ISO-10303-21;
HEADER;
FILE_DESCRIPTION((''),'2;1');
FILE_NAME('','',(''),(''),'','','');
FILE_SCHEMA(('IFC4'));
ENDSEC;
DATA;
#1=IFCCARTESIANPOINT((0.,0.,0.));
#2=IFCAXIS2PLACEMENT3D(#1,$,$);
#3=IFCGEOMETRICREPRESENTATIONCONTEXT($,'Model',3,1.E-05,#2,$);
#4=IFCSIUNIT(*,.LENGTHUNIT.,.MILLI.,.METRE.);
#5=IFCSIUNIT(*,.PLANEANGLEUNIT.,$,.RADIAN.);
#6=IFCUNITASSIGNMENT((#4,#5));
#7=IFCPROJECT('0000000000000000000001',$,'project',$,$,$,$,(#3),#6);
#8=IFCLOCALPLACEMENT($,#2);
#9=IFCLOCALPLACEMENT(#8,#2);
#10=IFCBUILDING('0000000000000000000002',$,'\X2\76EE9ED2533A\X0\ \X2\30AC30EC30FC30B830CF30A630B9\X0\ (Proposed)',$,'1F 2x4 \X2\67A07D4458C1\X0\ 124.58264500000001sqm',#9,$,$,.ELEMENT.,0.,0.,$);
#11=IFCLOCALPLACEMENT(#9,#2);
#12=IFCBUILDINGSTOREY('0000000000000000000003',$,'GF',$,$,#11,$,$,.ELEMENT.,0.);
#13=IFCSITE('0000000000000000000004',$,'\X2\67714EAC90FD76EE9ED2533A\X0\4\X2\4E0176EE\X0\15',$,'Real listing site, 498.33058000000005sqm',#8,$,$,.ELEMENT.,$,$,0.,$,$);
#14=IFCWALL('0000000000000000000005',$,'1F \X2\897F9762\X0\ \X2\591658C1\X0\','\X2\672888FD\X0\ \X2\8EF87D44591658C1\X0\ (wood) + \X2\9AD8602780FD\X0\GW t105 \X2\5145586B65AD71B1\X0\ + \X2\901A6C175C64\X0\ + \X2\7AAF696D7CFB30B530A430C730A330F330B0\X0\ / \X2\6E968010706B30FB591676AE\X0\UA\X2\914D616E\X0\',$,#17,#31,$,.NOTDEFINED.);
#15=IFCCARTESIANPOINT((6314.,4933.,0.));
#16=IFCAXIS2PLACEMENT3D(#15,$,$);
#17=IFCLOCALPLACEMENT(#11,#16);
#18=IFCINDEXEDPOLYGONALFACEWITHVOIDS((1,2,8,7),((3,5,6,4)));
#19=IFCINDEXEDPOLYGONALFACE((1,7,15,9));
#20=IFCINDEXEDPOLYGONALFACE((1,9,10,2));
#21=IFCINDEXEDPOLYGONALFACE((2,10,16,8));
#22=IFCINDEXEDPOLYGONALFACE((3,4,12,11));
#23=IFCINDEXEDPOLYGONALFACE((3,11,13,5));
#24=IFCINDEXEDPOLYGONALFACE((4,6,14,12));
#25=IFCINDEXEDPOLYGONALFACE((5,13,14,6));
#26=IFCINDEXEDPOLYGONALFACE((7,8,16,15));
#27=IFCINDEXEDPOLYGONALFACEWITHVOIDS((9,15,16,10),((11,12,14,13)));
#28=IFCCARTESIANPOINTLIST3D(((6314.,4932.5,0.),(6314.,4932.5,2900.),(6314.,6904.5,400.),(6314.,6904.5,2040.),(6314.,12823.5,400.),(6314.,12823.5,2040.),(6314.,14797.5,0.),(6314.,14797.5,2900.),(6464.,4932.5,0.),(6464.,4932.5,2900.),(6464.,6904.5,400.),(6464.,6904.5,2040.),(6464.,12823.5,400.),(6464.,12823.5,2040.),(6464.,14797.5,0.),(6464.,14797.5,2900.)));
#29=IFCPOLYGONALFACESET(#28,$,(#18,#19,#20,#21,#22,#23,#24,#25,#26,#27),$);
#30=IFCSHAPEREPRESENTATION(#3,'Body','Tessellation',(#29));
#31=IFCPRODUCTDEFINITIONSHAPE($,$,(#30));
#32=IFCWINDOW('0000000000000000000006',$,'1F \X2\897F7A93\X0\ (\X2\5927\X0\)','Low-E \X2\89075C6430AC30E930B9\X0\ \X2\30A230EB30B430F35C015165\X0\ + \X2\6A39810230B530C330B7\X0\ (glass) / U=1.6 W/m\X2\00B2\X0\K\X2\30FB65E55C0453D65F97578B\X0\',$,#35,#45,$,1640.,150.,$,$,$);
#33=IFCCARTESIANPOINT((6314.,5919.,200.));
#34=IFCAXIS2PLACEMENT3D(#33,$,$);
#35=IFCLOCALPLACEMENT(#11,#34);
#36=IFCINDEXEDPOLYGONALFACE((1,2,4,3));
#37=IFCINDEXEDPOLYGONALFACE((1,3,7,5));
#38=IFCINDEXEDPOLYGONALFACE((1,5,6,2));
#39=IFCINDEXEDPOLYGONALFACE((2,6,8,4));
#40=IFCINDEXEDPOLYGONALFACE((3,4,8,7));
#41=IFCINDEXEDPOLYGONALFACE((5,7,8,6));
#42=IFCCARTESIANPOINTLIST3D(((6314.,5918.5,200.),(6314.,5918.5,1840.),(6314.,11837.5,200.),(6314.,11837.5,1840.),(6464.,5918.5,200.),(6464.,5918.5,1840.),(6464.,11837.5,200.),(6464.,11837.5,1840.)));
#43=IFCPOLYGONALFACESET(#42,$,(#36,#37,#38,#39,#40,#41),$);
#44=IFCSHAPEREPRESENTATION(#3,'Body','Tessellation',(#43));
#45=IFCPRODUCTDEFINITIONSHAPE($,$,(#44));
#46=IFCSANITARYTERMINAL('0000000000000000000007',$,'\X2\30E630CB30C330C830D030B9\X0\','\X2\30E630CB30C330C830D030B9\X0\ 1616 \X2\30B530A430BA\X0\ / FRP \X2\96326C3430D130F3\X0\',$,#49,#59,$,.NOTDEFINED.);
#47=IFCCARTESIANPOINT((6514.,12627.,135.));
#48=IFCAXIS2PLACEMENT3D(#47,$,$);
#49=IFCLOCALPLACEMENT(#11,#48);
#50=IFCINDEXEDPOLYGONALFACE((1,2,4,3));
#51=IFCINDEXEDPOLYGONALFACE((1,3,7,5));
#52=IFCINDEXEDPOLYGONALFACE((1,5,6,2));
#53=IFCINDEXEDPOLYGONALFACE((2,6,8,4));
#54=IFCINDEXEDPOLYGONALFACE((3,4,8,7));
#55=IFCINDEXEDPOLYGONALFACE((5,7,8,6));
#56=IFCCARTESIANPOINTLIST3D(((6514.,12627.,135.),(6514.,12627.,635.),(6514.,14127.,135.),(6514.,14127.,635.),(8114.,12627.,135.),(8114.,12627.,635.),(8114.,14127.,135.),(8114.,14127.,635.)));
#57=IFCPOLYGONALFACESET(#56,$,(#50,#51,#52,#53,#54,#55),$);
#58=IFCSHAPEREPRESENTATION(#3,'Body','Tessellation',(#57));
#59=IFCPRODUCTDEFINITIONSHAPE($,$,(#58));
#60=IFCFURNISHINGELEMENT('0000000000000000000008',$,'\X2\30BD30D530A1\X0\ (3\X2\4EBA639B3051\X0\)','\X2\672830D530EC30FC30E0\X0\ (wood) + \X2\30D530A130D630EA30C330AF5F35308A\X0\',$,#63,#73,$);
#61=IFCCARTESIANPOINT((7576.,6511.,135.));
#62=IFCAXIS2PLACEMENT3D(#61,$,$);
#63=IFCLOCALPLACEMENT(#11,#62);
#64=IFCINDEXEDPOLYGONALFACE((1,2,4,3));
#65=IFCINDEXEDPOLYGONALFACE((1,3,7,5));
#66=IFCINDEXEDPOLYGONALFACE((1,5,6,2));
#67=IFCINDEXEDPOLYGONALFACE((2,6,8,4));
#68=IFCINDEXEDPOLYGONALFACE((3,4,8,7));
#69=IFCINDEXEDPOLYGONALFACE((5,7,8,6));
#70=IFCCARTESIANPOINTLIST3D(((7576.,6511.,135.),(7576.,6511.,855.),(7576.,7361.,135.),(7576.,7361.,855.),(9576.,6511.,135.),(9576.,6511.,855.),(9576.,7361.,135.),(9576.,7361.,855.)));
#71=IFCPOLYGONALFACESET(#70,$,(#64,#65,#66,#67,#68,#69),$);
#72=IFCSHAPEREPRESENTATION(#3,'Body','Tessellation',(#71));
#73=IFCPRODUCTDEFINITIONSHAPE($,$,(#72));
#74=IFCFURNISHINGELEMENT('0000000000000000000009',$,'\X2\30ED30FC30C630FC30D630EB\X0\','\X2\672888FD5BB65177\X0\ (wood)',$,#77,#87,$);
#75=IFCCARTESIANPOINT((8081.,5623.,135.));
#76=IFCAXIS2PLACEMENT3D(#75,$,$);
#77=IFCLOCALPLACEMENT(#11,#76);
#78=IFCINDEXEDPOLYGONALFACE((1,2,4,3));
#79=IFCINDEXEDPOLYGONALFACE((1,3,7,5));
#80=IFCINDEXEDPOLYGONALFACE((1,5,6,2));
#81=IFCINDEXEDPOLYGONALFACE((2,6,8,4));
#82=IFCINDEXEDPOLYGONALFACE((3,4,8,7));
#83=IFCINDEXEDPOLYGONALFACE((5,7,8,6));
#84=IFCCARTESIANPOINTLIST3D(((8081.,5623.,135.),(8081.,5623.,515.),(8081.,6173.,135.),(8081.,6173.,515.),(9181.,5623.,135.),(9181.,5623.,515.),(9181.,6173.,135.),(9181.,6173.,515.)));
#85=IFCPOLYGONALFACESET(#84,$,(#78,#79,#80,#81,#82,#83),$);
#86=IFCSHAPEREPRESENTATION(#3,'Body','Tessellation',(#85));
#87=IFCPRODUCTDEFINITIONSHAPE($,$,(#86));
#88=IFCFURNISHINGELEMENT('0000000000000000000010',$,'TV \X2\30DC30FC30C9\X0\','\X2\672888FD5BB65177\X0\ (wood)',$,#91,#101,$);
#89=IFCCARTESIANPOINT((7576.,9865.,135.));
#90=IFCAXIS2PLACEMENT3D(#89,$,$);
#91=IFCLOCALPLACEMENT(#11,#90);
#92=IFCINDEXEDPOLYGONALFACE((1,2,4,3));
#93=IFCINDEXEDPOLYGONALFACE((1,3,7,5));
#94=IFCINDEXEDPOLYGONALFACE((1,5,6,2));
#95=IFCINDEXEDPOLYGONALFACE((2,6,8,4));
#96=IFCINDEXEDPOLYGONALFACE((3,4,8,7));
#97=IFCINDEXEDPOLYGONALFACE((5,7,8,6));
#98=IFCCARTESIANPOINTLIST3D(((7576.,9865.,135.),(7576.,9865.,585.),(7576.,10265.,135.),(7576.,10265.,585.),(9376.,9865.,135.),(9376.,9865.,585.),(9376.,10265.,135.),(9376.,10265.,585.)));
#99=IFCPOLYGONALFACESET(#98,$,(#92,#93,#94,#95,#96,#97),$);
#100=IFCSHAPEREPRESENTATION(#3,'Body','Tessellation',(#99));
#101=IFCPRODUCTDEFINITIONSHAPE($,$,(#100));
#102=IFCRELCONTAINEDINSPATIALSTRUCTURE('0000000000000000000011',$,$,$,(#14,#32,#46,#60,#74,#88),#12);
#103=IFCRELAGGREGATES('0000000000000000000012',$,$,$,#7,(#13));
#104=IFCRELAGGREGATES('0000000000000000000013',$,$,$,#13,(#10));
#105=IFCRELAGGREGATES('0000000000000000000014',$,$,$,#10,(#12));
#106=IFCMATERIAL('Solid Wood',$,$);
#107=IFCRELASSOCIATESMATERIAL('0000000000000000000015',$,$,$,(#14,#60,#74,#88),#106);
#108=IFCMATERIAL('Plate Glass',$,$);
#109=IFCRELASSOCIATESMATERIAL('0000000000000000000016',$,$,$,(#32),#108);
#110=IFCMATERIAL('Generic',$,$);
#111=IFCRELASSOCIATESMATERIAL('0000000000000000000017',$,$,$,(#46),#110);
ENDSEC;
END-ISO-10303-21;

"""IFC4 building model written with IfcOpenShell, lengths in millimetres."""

from ifc_helpers import new_model, si_unit, frame, frame_2d, origin, place, context, project, spatial, rectangle, extrude, material, element, fill, save


model = new_model("IFC4")

# Units and contexts
model_context = context("Model", 3, precision=1e-05, world=origin())
ifc_project = project(units=[si_unit("LENGTHUNIT", "METRE", prefix="MILLI"), si_unit("PLANEANGLEUNIT", "RADIAN")], contexts=[model_context])

# Site, building, storey
site_placement = place(None, origin())
site = spatial("IfcSite", under=ifc_project, at=site_placement, Name="東京都目黒区4丁目15", ObjectType="Real listing site, 498.33058000000005sqm", CompositionType="ELEMENT", RefElevation=0.0)
building_placement = place(site_placement, origin())
building = spatial("IfcBuilding", under=site, at=building_placement, Name="目黒区 ガレージハウス (Proposed)", ObjectType="1F 2x4 枠組壁 124.58264500000001sqm", CompositionType="ELEMENT", ElevationOfRefHeight=0.0, ElevationOfTerrain=0.0)
storey_placement = place(building_placement, origin())
storey = spatial("IfcBuildingStorey", under=building, at=storey_placement, Name="GF", CompositionType="ELEMENT", Elevation=0.0)

# Shared definitions
ifc_material_1 = material(Name="Solid Wood")

# Shared definitions
ifc_material_2 = material(Name="Plate Glass")

# Wall, opening, window
wall_1_placement = place(storey_placement, frame((6314.0, 4933.0, 0.0)))
wall_1 = element("IfcWall", 1, at=wall_1_placement, inside=storey, material=ifc_material_1, Name="1F 西面 外壁", Description="木製 軸組外壁 (wood) + 高性能GW t105 充填断熱 + 通気層 + 窯業系サイディング / 準耐火・外皮UA配慮", PredefinedType="NOTDEFINED", context=model_context, shape_type="SweptSolid", body=[
    extrude(rectangle(XDim=150.0, YDim=9865.0, at=frame_2d((75.0, 4932.0))), frame((6314.0, 4933.0, 0.0)), (0.0, 0.0, 1.0), 2900.0),
])
opening_1_placement = place(storey_placement, frame((6314.0, 5919.0, 200.0)))
opening_1 = element("IfcOpeningElement", 2, at=opening_1_placement, cuts=wall_1, PredefinedType="NOTDEFINED", context=model_context, shape_type="SweptSolid", body=[
    extrude(rectangle(XDim=150.0, YDim=5919.0, at=frame_2d((75.0, 2959.0))), frame((6314.0, 5919.0, 200.0)), (0.0, 0.0, 1.0), 1640.0),
])
window_1_placement = place(storey_placement, frame((6314.0, 5919.0, 200.0)))
window_1 = element("IfcWindow", 3, at=window_1_placement, inside=storey, material=ifc_material_2, Name="1F 西窓 (大)", Description="Low-E 複層ガラス アルゴン封入 + 樹脂サッシ (glass) / U=1.6 W/m²K・日射取得型", OverallHeight=1640.0, OverallWidth=150.0, context=model_context, shape_type="SweptSolid", body=[
    extrude(rectangle(XDim=150.0, YDim=5919.0, at=frame_2d((75.0, 2959.0))), frame((6314.0, 5919.0, 200.0)), (0.0, 0.0, 1.0), 1640.0),
])
fill(opening_1, window_1)

# Shared definitions
ifc_material_3 = material(Name="Generic")

# Sanitary terminal
sanitary_terminal_placement = place(storey_placement, frame((6514.0, 12627.0, 135.0)))
element("IfcSanitaryTerminal", 4, at=sanitary_terminal_placement, inside=storey, material=ifc_material_3, Name="ユニットバス", Description="ユニットバス 1616 サイズ / FRP 防水パン", PredefinedType="NOTDEFINED", context=model_context, shape_type="SweptSolid", body=[
    extrude(rectangle(XDim=1600.0, YDim=1500.0, at=frame_2d((800.0, 750.0))), frame((6514.0, 12627.0, 135.0)), (0.0, 0.0, 1.0), 500.0),
])

# Furnishing elements
furnishing_1_placement = place(storey_placement, frame((7576.0, 6511.0, 135.0)))
element("IfcFurnishingElement", 5, at=furnishing_1_placement, inside=storey, material=ifc_material_1, Name="ソファ (3人掛け)", Description="木フレーム (wood) + ファブリック張り", context=model_context, shape_type="SweptSolid", body=[
    extrude(rectangle(XDim=2000.0, YDim=850.0, at=frame_2d((1000.0, 425.0))), frame((7576.0, 6511.0, 135.0)), (0.0, 0.0, 1.0), 720.0),
])
furnishing_2_placement = place(storey_placement, frame((8081.0, 5623.0, 135.0)))
element("IfcFurnishingElement", 6, at=furnishing_2_placement, inside=storey, material=ifc_material_1, Name="ローテーブル", Description="木製家具 (wood)", context=model_context, shape_type="SweptSolid", body=[
    extrude(rectangle(XDim=1100.0, YDim=550.0, at=frame_2d((550.0, 275.0))), frame((8081.0, 5623.0, 135.0)), (0.0, 0.0, 1.0), 380.0),
])
furnishing_3_placement = place(storey_placement, frame((7576.0, 9865.0, 135.0)))
element("IfcFurnishingElement", 7, at=furnishing_3_placement, inside=storey, material=ifc_material_1, Name="TV ボード", Description="木製家具 (wood)", context=model_context, shape_type="SweptSolid", body=[
    extrude(rectangle(XDim=1800.0, YDim=400.0, at=frame_2d((900.0, 200.0))), frame((7576.0, 9865.0, 135.0)), (0.0, 0.0, 1.0), 450.0),
])

save(model, "model.ifc")
